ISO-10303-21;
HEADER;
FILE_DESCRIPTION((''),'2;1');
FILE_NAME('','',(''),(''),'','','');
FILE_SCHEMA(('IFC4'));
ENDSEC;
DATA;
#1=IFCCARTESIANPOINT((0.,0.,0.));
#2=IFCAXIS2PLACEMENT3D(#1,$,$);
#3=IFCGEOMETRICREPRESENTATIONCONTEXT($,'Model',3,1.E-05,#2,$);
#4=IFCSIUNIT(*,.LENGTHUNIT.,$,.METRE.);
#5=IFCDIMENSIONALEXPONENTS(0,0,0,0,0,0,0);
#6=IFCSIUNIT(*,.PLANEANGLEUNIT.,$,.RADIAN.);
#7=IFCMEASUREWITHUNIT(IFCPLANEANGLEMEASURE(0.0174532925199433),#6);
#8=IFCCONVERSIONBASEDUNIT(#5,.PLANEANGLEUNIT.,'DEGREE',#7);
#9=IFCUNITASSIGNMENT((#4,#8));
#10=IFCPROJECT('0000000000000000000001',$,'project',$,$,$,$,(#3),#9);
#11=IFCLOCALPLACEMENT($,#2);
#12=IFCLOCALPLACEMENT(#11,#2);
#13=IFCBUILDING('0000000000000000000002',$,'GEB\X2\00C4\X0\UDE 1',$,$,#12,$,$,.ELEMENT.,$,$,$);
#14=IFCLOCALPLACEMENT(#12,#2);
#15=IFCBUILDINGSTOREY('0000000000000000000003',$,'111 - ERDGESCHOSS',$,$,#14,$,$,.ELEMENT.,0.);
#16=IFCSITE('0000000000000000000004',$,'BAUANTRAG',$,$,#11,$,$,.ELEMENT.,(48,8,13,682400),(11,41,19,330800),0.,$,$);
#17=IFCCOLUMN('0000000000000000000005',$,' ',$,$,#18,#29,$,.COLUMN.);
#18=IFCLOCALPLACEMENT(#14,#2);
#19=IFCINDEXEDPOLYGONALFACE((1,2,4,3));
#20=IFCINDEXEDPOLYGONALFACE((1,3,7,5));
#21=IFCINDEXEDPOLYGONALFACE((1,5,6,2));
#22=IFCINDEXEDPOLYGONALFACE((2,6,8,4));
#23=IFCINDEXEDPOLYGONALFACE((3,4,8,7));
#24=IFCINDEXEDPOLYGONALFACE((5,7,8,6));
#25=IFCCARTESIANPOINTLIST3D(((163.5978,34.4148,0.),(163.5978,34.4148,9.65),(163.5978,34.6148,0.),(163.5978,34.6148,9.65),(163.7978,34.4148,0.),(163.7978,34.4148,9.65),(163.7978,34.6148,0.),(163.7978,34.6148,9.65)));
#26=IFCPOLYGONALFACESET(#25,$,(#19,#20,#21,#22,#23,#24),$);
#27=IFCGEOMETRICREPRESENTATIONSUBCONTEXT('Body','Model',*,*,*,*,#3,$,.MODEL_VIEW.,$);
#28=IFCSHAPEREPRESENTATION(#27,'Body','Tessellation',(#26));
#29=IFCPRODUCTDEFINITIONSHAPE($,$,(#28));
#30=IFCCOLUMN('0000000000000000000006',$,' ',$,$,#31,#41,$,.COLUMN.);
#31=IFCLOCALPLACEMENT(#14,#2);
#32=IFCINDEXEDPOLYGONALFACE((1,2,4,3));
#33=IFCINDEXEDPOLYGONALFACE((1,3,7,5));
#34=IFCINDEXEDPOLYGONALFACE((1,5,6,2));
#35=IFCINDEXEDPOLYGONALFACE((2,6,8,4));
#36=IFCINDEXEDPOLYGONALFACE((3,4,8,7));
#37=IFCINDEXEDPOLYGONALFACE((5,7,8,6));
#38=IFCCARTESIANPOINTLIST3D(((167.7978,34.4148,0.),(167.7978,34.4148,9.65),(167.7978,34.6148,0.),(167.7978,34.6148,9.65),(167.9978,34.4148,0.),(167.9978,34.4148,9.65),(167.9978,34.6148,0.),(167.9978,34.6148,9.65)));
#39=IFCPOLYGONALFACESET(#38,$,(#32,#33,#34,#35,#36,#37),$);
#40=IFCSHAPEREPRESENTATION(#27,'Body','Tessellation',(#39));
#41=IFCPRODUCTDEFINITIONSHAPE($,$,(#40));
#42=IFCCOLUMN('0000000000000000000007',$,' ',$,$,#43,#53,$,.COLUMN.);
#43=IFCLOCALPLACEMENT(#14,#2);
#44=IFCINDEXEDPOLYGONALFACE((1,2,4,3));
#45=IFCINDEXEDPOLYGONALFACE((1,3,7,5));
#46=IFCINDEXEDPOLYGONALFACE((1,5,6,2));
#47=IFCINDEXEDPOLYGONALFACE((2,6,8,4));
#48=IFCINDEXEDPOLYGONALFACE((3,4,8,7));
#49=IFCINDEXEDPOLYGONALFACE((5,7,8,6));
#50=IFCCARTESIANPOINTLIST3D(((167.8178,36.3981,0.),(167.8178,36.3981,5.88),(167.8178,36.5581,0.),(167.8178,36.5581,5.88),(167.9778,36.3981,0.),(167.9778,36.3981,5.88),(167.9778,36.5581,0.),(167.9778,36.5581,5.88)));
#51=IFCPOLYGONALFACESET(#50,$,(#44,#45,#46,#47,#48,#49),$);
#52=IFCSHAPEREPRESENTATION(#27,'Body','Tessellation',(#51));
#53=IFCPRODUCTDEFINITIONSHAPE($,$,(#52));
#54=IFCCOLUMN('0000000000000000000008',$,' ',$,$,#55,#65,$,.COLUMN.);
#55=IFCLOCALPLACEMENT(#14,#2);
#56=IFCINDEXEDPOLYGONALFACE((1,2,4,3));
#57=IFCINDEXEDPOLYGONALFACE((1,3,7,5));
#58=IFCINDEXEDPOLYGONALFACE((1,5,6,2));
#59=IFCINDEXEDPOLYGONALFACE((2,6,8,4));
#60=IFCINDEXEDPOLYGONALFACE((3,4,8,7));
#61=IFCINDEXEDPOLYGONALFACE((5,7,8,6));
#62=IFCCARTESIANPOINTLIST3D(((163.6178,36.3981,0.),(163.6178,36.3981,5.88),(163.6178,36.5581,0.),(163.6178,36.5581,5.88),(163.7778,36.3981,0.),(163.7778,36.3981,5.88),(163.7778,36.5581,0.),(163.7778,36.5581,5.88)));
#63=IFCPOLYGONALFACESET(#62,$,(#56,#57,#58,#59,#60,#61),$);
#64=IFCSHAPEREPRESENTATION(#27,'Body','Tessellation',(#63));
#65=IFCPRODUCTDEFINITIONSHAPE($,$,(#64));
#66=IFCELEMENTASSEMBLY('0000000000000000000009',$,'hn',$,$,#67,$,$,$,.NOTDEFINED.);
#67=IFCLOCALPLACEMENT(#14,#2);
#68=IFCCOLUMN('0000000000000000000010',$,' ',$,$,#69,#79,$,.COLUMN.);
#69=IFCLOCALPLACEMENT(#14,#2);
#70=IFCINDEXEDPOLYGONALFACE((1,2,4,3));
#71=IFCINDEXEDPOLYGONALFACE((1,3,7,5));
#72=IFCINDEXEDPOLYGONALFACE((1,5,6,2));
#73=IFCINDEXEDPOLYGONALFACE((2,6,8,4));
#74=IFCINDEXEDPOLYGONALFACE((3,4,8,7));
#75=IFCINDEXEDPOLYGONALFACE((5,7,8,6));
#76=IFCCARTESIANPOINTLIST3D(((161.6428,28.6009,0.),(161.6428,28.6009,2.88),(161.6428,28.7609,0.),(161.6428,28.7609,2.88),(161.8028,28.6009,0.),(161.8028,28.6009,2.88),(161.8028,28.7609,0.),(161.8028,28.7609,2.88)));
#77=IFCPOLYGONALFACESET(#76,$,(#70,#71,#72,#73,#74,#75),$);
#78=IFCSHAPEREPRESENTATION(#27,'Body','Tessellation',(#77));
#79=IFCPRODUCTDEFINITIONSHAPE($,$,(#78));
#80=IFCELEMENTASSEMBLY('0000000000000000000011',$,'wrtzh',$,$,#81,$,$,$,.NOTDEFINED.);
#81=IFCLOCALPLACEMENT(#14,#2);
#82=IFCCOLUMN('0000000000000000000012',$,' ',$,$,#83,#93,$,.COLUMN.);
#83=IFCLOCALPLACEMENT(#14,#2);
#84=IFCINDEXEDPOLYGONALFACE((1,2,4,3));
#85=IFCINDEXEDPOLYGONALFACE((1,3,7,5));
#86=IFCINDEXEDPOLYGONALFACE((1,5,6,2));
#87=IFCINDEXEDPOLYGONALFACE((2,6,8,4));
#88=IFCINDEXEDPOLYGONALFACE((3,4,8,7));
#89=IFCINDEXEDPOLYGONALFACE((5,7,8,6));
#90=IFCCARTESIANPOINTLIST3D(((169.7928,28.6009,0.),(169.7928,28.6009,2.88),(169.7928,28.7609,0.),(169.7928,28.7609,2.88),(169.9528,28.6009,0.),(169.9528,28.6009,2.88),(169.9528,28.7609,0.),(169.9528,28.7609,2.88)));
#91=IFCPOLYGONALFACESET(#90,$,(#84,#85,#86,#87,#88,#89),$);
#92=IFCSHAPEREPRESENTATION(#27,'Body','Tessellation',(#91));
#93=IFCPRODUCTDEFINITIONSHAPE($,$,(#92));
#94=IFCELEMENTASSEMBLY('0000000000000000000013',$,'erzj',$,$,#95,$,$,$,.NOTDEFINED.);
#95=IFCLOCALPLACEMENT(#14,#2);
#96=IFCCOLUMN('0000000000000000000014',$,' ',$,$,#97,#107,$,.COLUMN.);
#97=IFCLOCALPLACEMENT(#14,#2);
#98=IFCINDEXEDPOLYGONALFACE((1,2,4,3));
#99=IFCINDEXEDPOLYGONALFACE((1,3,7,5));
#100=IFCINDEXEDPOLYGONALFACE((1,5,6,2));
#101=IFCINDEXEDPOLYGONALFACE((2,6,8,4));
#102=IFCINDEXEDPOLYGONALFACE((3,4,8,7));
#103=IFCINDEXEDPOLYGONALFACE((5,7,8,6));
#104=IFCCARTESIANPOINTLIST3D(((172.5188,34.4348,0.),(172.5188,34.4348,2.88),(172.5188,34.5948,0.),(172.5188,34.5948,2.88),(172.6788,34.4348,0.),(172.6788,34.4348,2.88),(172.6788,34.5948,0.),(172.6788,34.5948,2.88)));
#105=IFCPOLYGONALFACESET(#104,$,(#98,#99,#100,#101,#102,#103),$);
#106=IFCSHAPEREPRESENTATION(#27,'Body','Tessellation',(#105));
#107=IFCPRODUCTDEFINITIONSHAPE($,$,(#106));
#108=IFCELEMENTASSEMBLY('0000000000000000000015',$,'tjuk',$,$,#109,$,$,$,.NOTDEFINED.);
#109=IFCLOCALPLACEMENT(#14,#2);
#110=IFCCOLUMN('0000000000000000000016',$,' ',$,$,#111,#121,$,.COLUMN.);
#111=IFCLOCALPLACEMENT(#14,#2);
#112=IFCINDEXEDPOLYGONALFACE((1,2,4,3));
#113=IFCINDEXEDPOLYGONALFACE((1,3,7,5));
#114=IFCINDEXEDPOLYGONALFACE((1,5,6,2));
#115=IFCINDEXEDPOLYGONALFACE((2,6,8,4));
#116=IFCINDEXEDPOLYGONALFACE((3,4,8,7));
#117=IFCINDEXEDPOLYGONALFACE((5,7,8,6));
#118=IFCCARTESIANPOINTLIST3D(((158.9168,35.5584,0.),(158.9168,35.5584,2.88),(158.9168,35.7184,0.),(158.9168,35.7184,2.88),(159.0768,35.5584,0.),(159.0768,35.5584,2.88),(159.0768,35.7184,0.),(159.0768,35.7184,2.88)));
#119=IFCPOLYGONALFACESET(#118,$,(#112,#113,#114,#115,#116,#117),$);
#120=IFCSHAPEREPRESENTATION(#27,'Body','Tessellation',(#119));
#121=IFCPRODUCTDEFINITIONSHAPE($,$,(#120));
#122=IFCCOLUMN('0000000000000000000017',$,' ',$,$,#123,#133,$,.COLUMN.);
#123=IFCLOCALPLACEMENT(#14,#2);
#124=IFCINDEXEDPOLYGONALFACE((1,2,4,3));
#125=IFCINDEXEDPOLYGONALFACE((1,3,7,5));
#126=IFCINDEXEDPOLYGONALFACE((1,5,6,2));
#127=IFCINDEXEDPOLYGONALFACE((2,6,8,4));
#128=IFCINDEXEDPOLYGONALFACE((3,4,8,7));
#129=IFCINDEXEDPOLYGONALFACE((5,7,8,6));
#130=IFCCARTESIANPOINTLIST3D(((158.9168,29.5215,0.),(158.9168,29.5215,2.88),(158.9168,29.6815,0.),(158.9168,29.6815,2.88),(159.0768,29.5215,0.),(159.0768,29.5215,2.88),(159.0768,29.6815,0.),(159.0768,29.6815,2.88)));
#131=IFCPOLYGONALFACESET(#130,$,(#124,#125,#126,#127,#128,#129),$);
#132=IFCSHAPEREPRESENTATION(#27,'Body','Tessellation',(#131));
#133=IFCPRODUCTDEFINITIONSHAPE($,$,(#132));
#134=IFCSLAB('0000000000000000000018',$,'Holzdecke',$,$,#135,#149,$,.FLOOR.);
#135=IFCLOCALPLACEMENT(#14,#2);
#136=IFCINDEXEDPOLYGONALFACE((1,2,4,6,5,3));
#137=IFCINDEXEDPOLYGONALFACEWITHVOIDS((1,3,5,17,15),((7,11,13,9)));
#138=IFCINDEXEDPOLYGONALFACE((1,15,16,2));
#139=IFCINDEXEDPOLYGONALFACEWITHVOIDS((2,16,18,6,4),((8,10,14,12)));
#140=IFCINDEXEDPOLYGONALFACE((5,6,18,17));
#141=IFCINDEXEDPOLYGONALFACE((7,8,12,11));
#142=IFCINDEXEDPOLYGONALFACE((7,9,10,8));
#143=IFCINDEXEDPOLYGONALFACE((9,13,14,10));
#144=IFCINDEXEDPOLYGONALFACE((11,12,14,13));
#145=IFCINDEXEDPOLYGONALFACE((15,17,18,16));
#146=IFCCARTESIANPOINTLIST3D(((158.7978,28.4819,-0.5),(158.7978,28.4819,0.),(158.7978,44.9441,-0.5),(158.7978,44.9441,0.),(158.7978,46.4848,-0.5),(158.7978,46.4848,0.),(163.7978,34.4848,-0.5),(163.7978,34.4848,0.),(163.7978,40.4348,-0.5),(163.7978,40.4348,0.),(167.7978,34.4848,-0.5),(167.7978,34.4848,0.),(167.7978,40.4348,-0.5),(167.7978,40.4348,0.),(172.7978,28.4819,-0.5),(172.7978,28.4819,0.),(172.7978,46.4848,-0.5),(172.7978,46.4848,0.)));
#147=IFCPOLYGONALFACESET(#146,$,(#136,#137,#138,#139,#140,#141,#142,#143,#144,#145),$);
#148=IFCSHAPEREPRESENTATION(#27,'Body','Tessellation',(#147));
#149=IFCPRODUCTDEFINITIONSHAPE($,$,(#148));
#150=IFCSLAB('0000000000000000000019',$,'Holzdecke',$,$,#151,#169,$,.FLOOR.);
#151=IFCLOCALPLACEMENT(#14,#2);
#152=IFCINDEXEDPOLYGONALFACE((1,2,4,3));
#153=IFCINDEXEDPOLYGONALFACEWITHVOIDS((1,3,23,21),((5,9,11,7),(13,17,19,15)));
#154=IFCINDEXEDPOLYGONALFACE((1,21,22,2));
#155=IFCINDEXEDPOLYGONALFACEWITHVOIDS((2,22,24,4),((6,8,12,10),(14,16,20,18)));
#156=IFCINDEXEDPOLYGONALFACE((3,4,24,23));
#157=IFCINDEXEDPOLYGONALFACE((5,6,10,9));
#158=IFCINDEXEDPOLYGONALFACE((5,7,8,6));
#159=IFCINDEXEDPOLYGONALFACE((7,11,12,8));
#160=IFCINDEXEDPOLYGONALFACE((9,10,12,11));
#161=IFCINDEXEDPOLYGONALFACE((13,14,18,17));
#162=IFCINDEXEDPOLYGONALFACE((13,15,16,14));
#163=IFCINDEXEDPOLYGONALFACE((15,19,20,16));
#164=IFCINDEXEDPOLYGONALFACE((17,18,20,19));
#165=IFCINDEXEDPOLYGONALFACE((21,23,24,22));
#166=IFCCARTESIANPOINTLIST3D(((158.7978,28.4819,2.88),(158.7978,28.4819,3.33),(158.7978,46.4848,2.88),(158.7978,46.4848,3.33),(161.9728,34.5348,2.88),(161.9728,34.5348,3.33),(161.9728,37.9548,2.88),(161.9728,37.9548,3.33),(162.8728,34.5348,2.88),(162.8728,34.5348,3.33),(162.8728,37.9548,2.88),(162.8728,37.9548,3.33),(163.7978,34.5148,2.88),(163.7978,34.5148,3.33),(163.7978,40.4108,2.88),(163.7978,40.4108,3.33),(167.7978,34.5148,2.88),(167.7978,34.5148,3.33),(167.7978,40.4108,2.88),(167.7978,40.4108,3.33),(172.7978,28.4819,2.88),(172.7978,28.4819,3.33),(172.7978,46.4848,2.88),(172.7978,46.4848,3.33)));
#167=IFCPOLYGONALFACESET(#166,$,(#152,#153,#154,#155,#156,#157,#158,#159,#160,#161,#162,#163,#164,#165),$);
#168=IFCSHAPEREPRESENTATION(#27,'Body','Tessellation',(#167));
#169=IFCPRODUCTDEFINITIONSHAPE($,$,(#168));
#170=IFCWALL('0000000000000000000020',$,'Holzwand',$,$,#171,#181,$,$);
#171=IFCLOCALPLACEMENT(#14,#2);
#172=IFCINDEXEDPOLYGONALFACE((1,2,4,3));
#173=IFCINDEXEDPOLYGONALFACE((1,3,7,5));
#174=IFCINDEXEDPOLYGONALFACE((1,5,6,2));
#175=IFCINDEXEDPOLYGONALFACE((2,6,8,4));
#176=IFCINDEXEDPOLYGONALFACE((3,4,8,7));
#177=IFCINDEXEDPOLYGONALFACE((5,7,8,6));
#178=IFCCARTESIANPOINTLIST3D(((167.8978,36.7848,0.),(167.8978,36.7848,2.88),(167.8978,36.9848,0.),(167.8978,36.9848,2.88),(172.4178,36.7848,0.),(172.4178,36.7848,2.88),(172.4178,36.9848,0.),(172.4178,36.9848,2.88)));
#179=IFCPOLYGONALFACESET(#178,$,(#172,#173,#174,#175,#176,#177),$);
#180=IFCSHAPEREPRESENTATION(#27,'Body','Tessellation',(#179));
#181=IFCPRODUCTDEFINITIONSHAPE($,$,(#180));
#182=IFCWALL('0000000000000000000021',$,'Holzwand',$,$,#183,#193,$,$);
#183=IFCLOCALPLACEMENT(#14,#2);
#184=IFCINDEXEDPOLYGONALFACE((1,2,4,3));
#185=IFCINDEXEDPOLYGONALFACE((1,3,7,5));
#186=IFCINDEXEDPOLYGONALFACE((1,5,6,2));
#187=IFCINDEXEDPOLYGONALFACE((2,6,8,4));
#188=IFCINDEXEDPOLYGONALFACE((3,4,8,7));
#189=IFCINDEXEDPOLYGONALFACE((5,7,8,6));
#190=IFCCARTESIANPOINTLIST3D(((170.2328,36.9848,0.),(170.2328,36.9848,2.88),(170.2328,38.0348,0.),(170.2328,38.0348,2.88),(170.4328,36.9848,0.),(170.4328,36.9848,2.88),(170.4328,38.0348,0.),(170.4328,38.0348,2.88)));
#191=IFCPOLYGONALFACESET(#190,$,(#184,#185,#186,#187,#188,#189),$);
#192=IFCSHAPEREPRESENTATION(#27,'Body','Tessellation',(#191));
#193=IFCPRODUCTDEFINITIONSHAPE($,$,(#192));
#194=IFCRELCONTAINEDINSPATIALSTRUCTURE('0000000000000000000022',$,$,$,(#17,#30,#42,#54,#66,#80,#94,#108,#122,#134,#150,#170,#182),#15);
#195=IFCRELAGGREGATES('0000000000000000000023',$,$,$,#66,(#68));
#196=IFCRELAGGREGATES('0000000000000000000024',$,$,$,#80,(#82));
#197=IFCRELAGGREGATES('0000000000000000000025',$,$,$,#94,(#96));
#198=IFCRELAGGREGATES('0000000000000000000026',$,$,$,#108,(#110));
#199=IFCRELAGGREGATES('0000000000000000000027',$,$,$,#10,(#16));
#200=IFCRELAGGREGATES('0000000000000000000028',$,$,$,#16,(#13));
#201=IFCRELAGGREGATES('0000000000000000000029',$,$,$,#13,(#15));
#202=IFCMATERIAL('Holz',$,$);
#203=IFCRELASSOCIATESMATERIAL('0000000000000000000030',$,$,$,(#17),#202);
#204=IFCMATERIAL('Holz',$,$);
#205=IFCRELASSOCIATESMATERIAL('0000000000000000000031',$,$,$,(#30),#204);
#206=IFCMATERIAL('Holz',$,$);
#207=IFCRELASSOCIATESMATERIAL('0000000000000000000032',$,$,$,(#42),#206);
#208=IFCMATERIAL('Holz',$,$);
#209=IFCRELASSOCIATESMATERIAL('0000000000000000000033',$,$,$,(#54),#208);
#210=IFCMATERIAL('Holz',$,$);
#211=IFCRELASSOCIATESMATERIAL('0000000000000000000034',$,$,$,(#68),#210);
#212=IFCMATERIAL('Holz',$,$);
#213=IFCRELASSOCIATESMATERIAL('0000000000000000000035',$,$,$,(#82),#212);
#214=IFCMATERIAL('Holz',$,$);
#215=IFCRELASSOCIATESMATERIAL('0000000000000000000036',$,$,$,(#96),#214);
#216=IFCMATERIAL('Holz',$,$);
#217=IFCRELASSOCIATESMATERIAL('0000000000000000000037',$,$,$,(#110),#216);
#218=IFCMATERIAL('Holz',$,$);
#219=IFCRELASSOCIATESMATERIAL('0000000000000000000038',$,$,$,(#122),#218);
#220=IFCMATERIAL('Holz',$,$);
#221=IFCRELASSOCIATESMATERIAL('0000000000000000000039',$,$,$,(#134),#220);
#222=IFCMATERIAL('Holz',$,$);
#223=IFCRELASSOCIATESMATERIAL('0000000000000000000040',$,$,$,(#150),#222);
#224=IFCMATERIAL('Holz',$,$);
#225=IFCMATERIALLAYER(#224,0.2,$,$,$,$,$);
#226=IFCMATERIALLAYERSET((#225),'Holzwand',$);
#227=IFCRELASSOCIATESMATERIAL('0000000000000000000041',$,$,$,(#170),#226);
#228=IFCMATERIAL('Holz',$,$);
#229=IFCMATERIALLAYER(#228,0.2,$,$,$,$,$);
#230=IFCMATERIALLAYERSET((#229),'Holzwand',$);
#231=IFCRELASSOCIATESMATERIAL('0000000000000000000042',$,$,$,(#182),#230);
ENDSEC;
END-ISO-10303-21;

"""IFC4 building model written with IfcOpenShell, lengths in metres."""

from ifc_helpers import new_model, entity, si_unit, converted_unit, frame, frame_2d, origin, origin_with_axes, place, context, subcontext, project, spatial, polyline, rectangle, outline, extrude, material, layer, layer_set, layer_usage, element, aggregate, save


model = new_model("IFC4")

# Units and contexts
model_context = context("Model", 3, precision=1e-05, world=origin())
body_context = subcontext(model_context, "Body", "Model", "MODEL_VIEW")
ifc_project = project(units=[si_unit("LENGTHUNIT", "METRE"), converted_unit("PLANEANGLEUNIT", "DEGREE", entity("IfcPlaneAngleMeasure", 0.0174532925199433), si_unit("PLANEANGLEUNIT", "RADIAN"), dimensions=[0, 0, 0, 0, 0, 0, 0])], contexts=[model_context])

# Site, building, storey
site_placement = place(None, origin())
site = spatial("IfcSite", under=ifc_project, at=site_placement, Name="BAUANTRAG", CompositionType="ELEMENT", RefLatitude=(48, 8, 13, 682400), RefLongitude=(11, 41, 19, 330800), RefElevation=0.0)
building_placement = place(site_placement, origin())
building = spatial("IfcBuilding", under=site, at=building_placement, Name="GEBÄUDE 1", CompositionType="ELEMENT")
storey_placement = place(building_placement, origin())
storey = spatial("IfcBuildingStorey", under=building, at=storey_placement, Name="111 - ERDGESCHOSS", CompositionType="ELEMENT", Elevation=0.0)

# Columns
ifc_material_1 = material(Name="Holz")
column_1_placement = place(storey_placement, frame((163.5978, 34.4148, 0.0)))
element("IfcColumn", 1, at=column_1_placement, inside=storey, material=ifc_material_1, Name=" ", PredefinedType="COLUMN", context=body_context, shape_type="SweptSolid", body=[
    extrude(rectangle(XDim=0.2, YDim=0.2, at=frame_2d((0.1, 0.1), x_axis=(1.0, 0.0))), origin_with_axes(), (0.0, 0.0, 1.0), 9.65),
])
ifc_material_2 = material(Name="Holz")
column_2_placement = place(storey_placement, frame((167.7978, 34.4148, 0.0)))
element("IfcColumn", 2, at=column_2_placement, inside=storey, material=ifc_material_2, Name=" ", PredefinedType="COLUMN", context=body_context, shape_type="SweptSolid", body=[
    extrude(rectangle(XDim=0.2, YDim=0.2, at=frame_2d((0.1, 0.1), x_axis=(1.0, 0.0))), origin_with_axes(), (0.0, 0.0, 1.0), 9.65),
])
ifc_material_3 = material(Name="Holz")
column_3_placement = place(storey_placement, frame((167.8178, 36.3981, 0.0)))
element("IfcColumn", 3, at=column_3_placement, inside=storey, material=ifc_material_3, Name=" ", PredefinedType="COLUMN", context=body_context, shape_type="SweptSolid", body=[
    extrude(rectangle(XDim=0.16, YDim=0.16, at=frame_2d((0.08, 0.08), x_axis=(1.0, 0.0))), origin_with_axes(), (0.0, 0.0, 1.0), 5.88),
])
ifc_material_4 = material(Name="Holz")
column_4_placement = place(storey_placement, frame((163.6178, 36.3981, 0.0)))
element("IfcColumn", 4, at=column_4_placement, inside=storey, material=ifc_material_4, Name=" ", PredefinedType="COLUMN", context=body_context, shape_type="SweptSolid", body=[
    extrude(rectangle(XDim=0.16, YDim=0.16, at=frame_2d((0.08, 0.08), x_axis=(1.0, 0.0))), origin_with_axes(), (0.0, 0.0, 1.0), 5.88),
])

# Element assemblies, columns
assembly_1_placement = place(storey_placement, origin())
assembly_1 = element("IfcElementAssembly", 5, at=assembly_1_placement, inside=storey, Name="hn", PredefinedType="NOTDEFINED")
ifc_material_5 = material(Name="Holz")
column_5_placement = place(assembly_1_placement, frame((161.6428, 28.6009, 0.0)))
column_5 = element("IfcColumn", 6, at=column_5_placement, material=ifc_material_5, Name=" ", PredefinedType="COLUMN", context=body_context, shape_type="SweptSolid", body=[
    extrude(rectangle(XDim=0.16, YDim=0.16, at=frame_2d((0.08, 0.08), x_axis=(1.0, 0.0))), origin_with_axes(), (0.0, 0.0, 1.0), 2.88),
])
aggregate(assembly_1, [column_5])
assembly_2_placement = place(storey_placement, origin())
assembly_2 = element("IfcElementAssembly", 7, at=assembly_2_placement, inside=storey, Name="wrtzh", PredefinedType="NOTDEFINED")
ifc_material_6 = material(Name="Holz")
column_6_placement = place(assembly_2_placement, frame((169.7928, 28.6009, 0.0)))
column_6 = element("IfcColumn", 8, at=column_6_placement, material=ifc_material_6, Name=" ", PredefinedType="COLUMN", context=body_context, shape_type="SweptSolid", body=[
    extrude(rectangle(XDim=0.16, YDim=0.16, at=frame_2d((0.08, 0.08), x_axis=(1.0, 0.0))), origin_with_axes(), (0.0, 0.0, 1.0), 2.88),
])
aggregate(assembly_2, [column_6])
assembly_3_placement = place(storey_placement, origin())
assembly_3 = element("IfcElementAssembly", 9, at=assembly_3_placement, inside=storey, Name="erzj", PredefinedType="NOTDEFINED")
ifc_material_7 = material(Name="Holz")
column_7_placement = place(assembly_3_placement, frame((172.5188, 34.4348, 0.0)))
column_7 = element("IfcColumn", 10, at=column_7_placement, material=ifc_material_7, Name=" ", PredefinedType="COLUMN", context=body_context, shape_type="SweptSolid", body=[
    extrude(rectangle(XDim=0.16, YDim=0.16, at=frame_2d((0.08, 0.08), x_axis=(1.0, 0.0))), origin_with_axes(), (0.0, 0.0, 1.0), 2.88),
])
aggregate(assembly_3, [column_7])
assembly_4_placement = place(storey_placement, origin())
assembly_4 = element("IfcElementAssembly", 11, at=assembly_4_placement, inside=storey, Name="tjuk", PredefinedType="NOTDEFINED")
ifc_material_8 = material(Name="Holz")
column_8_placement = place(assembly_4_placement, frame((158.9168, 35.5584, 0.0)))
column_8 = element("IfcColumn", 12, at=column_8_placement, material=ifc_material_8, Name=" ", PredefinedType="COLUMN", context=body_context, shape_type="SweptSolid", body=[
    extrude(rectangle(XDim=0.16, YDim=0.16, at=frame_2d((0.08, 0.08), x_axis=(1.0, 0.0))), origin_with_axes(), (0.0, 0.0, 1.0), 2.88),
])
aggregate(assembly_4, [column_8])

# Column
ifc_material_9 = material(Name="Holz")
column_9_placement = place(storey_placement, frame((158.9168, 29.5215, 0.0)))
element("IfcColumn", 13, at=column_9_placement, inside=storey, material=ifc_material_9, Name=" ", PredefinedType="COLUMN", context=body_context, shape_type="SweptSolid", body=[
    extrude(rectangle(XDim=0.16, YDim=0.16, at=frame_2d((0.08, 0.08), x_axis=(1.0, 0.0))), origin_with_axes(), (0.0, 0.0, 1.0), 2.88),
])

# Slab
ifc_material_10 = material(Name="Holz")
slab_1_placement = place(storey_placement, frame((158.7978, 28.4819, -0.5)))
element("IfcSlab", 14, at=slab_1_placement, inside=storey, material=ifc_material_10, Name="Holzdecke", PredefinedType="FLOOR", context=body_context, shape_type="SweptSolid", body=[
    extrude(outline(polyline([(0.0, 16.4622), (0.0, 0.0), (14.0, 0.0), (14.0, 18.0029), (0.0, 18.0029), (0.0, 16.4622)]), holes=[polyline([(5.0, 11.9529), (9.0, 11.9529), (9.0, 6.0029), (5.0, 6.0029), (5.0, 11.9529)])]), origin_with_axes(), (0.0, 0.0, 1.0), 0.5),
])

# Slab, openings
ifc_material_11 = material(Name="Holz")
slab_2_placement = place(storey_placement, frame((158.7978, 28.4819, 2.88)))
slab_2 = element("IfcSlab", 15, at=slab_2_placement, inside=storey, material=ifc_material_11, Name="Holzdecke", PredefinedType="FLOOR", context=body_context, shape_type="SweptSolid", body=[
    extrude(rectangle(XDim=18.0029, YDim=14.0, at=frame_2d((-7.0, 9.0014), x_axis=(0.0, 1.0))), frame((14.0, 0.0, 0.0), z_axis=(0.0, 0.0, 1.0), x_axis=(1.0, 0.0, 0.0)), (0.0, 0.0, 1.0), 0.45),
])
opening_1_placement = place(slab_2_placement, frame((3.175, 6.0529, 0.0)))
element("IfcOpeningElement", 16, at=opening_1_placement, cuts=slab_2, ObjectType="Opening", context=body_context, shape_type="SweptSolid", body=[
    extrude(rectangle(XDim=0.9, YDim=3.42, at=frame_2d((0.0, 0.0), x_axis=(-1.0, 0.0))), frame((0.45, 1.71, 0.0), z_axis=(0.0, 0.0, 1.0), x_axis=(1.0, 0.0, 0.0)), (0.0, 0.0, 1.0), 0.45),
])
opening_2_placement = place(slab_2_placement, frame((5.0, 6.0329, 0.0)))
element("IfcOpeningElement", 17, at=opening_2_placement, cuts=slab_2, ObjectType="Opening", context=body_context, shape_type="SweptSolid", body=[
    extrude(rectangle(XDim=4.0, YDim=5.896, at=frame_2d((0.0, 0.0), x_axis=(-1.0, 0.0))), frame((2.0, 2.948, 0.0), z_axis=(0.0, 0.0, 1.0), x_axis=(1.0, 0.0, 0.0)), (0.0, 0.0, 1.0), 0.45),
])

# Walls
ifc_material_12 = material(Name="Holz")
ifc_layer_1 = layer(ifc_material_12, 0.2)
ifc_layer_set_1 = layer_set([ifc_layer_1], Name="Holzwand")
ifc_layer_usage_1 = layer_usage(ifc_layer_set_1, "AXIS2", "POSITIVE", 0.0)
wall_1_placement = place(storey_placement, frame((172.4178, 36.9848, 0.0), z_axis=(0.0, 0.0, 1.0), x_axis=(-1.0, 0.0, 0.0)))
element("IfcWall", 18, at=wall_1_placement, inside=storey, material=ifc_layer_usage_1, Name="Holzwand", context=body_context, shape_type="SweptSolid", body=[
    extrude(rectangle(XDim=4.52, YDim=0.2, at=frame_2d((2.26, 0.1), x_axis=(1.0, 0.0))), origin_with_axes(), (0.0, 0.0, 1.0), 2.88),
])
ifc_material_13 = material(Name="Holz")
ifc_layer_2 = layer(ifc_material_13, 0.2)
ifc_layer_set_2 = layer_set([ifc_layer_2], Name="Holzwand")
ifc_layer_usage_2 = layer_usage(ifc_layer_set_2, "AXIS2", "POSITIVE", -0.075)
wall_2_placement = place(storey_placement, frame((170.4328, 36.9848, 0.0), z_axis=(0.0, 0.0, 1.0), x_axis=(0.0, 1.0, 0.0)))
element("IfcWall", 19, at=wall_2_placement, inside=storey, material=ifc_layer_usage_2, Name="Holzwand", context=body_context, shape_type="SweptSolid", body=[
    extrude(rectangle(XDim=1.05, YDim=0.2, at=frame_2d((0.525, 0.1), x_axis=(1.0, 0.0))), origin_with_axes(), (0.0, 0.0, 1.0), 2.88),
])

save(model, "model.ifc")
